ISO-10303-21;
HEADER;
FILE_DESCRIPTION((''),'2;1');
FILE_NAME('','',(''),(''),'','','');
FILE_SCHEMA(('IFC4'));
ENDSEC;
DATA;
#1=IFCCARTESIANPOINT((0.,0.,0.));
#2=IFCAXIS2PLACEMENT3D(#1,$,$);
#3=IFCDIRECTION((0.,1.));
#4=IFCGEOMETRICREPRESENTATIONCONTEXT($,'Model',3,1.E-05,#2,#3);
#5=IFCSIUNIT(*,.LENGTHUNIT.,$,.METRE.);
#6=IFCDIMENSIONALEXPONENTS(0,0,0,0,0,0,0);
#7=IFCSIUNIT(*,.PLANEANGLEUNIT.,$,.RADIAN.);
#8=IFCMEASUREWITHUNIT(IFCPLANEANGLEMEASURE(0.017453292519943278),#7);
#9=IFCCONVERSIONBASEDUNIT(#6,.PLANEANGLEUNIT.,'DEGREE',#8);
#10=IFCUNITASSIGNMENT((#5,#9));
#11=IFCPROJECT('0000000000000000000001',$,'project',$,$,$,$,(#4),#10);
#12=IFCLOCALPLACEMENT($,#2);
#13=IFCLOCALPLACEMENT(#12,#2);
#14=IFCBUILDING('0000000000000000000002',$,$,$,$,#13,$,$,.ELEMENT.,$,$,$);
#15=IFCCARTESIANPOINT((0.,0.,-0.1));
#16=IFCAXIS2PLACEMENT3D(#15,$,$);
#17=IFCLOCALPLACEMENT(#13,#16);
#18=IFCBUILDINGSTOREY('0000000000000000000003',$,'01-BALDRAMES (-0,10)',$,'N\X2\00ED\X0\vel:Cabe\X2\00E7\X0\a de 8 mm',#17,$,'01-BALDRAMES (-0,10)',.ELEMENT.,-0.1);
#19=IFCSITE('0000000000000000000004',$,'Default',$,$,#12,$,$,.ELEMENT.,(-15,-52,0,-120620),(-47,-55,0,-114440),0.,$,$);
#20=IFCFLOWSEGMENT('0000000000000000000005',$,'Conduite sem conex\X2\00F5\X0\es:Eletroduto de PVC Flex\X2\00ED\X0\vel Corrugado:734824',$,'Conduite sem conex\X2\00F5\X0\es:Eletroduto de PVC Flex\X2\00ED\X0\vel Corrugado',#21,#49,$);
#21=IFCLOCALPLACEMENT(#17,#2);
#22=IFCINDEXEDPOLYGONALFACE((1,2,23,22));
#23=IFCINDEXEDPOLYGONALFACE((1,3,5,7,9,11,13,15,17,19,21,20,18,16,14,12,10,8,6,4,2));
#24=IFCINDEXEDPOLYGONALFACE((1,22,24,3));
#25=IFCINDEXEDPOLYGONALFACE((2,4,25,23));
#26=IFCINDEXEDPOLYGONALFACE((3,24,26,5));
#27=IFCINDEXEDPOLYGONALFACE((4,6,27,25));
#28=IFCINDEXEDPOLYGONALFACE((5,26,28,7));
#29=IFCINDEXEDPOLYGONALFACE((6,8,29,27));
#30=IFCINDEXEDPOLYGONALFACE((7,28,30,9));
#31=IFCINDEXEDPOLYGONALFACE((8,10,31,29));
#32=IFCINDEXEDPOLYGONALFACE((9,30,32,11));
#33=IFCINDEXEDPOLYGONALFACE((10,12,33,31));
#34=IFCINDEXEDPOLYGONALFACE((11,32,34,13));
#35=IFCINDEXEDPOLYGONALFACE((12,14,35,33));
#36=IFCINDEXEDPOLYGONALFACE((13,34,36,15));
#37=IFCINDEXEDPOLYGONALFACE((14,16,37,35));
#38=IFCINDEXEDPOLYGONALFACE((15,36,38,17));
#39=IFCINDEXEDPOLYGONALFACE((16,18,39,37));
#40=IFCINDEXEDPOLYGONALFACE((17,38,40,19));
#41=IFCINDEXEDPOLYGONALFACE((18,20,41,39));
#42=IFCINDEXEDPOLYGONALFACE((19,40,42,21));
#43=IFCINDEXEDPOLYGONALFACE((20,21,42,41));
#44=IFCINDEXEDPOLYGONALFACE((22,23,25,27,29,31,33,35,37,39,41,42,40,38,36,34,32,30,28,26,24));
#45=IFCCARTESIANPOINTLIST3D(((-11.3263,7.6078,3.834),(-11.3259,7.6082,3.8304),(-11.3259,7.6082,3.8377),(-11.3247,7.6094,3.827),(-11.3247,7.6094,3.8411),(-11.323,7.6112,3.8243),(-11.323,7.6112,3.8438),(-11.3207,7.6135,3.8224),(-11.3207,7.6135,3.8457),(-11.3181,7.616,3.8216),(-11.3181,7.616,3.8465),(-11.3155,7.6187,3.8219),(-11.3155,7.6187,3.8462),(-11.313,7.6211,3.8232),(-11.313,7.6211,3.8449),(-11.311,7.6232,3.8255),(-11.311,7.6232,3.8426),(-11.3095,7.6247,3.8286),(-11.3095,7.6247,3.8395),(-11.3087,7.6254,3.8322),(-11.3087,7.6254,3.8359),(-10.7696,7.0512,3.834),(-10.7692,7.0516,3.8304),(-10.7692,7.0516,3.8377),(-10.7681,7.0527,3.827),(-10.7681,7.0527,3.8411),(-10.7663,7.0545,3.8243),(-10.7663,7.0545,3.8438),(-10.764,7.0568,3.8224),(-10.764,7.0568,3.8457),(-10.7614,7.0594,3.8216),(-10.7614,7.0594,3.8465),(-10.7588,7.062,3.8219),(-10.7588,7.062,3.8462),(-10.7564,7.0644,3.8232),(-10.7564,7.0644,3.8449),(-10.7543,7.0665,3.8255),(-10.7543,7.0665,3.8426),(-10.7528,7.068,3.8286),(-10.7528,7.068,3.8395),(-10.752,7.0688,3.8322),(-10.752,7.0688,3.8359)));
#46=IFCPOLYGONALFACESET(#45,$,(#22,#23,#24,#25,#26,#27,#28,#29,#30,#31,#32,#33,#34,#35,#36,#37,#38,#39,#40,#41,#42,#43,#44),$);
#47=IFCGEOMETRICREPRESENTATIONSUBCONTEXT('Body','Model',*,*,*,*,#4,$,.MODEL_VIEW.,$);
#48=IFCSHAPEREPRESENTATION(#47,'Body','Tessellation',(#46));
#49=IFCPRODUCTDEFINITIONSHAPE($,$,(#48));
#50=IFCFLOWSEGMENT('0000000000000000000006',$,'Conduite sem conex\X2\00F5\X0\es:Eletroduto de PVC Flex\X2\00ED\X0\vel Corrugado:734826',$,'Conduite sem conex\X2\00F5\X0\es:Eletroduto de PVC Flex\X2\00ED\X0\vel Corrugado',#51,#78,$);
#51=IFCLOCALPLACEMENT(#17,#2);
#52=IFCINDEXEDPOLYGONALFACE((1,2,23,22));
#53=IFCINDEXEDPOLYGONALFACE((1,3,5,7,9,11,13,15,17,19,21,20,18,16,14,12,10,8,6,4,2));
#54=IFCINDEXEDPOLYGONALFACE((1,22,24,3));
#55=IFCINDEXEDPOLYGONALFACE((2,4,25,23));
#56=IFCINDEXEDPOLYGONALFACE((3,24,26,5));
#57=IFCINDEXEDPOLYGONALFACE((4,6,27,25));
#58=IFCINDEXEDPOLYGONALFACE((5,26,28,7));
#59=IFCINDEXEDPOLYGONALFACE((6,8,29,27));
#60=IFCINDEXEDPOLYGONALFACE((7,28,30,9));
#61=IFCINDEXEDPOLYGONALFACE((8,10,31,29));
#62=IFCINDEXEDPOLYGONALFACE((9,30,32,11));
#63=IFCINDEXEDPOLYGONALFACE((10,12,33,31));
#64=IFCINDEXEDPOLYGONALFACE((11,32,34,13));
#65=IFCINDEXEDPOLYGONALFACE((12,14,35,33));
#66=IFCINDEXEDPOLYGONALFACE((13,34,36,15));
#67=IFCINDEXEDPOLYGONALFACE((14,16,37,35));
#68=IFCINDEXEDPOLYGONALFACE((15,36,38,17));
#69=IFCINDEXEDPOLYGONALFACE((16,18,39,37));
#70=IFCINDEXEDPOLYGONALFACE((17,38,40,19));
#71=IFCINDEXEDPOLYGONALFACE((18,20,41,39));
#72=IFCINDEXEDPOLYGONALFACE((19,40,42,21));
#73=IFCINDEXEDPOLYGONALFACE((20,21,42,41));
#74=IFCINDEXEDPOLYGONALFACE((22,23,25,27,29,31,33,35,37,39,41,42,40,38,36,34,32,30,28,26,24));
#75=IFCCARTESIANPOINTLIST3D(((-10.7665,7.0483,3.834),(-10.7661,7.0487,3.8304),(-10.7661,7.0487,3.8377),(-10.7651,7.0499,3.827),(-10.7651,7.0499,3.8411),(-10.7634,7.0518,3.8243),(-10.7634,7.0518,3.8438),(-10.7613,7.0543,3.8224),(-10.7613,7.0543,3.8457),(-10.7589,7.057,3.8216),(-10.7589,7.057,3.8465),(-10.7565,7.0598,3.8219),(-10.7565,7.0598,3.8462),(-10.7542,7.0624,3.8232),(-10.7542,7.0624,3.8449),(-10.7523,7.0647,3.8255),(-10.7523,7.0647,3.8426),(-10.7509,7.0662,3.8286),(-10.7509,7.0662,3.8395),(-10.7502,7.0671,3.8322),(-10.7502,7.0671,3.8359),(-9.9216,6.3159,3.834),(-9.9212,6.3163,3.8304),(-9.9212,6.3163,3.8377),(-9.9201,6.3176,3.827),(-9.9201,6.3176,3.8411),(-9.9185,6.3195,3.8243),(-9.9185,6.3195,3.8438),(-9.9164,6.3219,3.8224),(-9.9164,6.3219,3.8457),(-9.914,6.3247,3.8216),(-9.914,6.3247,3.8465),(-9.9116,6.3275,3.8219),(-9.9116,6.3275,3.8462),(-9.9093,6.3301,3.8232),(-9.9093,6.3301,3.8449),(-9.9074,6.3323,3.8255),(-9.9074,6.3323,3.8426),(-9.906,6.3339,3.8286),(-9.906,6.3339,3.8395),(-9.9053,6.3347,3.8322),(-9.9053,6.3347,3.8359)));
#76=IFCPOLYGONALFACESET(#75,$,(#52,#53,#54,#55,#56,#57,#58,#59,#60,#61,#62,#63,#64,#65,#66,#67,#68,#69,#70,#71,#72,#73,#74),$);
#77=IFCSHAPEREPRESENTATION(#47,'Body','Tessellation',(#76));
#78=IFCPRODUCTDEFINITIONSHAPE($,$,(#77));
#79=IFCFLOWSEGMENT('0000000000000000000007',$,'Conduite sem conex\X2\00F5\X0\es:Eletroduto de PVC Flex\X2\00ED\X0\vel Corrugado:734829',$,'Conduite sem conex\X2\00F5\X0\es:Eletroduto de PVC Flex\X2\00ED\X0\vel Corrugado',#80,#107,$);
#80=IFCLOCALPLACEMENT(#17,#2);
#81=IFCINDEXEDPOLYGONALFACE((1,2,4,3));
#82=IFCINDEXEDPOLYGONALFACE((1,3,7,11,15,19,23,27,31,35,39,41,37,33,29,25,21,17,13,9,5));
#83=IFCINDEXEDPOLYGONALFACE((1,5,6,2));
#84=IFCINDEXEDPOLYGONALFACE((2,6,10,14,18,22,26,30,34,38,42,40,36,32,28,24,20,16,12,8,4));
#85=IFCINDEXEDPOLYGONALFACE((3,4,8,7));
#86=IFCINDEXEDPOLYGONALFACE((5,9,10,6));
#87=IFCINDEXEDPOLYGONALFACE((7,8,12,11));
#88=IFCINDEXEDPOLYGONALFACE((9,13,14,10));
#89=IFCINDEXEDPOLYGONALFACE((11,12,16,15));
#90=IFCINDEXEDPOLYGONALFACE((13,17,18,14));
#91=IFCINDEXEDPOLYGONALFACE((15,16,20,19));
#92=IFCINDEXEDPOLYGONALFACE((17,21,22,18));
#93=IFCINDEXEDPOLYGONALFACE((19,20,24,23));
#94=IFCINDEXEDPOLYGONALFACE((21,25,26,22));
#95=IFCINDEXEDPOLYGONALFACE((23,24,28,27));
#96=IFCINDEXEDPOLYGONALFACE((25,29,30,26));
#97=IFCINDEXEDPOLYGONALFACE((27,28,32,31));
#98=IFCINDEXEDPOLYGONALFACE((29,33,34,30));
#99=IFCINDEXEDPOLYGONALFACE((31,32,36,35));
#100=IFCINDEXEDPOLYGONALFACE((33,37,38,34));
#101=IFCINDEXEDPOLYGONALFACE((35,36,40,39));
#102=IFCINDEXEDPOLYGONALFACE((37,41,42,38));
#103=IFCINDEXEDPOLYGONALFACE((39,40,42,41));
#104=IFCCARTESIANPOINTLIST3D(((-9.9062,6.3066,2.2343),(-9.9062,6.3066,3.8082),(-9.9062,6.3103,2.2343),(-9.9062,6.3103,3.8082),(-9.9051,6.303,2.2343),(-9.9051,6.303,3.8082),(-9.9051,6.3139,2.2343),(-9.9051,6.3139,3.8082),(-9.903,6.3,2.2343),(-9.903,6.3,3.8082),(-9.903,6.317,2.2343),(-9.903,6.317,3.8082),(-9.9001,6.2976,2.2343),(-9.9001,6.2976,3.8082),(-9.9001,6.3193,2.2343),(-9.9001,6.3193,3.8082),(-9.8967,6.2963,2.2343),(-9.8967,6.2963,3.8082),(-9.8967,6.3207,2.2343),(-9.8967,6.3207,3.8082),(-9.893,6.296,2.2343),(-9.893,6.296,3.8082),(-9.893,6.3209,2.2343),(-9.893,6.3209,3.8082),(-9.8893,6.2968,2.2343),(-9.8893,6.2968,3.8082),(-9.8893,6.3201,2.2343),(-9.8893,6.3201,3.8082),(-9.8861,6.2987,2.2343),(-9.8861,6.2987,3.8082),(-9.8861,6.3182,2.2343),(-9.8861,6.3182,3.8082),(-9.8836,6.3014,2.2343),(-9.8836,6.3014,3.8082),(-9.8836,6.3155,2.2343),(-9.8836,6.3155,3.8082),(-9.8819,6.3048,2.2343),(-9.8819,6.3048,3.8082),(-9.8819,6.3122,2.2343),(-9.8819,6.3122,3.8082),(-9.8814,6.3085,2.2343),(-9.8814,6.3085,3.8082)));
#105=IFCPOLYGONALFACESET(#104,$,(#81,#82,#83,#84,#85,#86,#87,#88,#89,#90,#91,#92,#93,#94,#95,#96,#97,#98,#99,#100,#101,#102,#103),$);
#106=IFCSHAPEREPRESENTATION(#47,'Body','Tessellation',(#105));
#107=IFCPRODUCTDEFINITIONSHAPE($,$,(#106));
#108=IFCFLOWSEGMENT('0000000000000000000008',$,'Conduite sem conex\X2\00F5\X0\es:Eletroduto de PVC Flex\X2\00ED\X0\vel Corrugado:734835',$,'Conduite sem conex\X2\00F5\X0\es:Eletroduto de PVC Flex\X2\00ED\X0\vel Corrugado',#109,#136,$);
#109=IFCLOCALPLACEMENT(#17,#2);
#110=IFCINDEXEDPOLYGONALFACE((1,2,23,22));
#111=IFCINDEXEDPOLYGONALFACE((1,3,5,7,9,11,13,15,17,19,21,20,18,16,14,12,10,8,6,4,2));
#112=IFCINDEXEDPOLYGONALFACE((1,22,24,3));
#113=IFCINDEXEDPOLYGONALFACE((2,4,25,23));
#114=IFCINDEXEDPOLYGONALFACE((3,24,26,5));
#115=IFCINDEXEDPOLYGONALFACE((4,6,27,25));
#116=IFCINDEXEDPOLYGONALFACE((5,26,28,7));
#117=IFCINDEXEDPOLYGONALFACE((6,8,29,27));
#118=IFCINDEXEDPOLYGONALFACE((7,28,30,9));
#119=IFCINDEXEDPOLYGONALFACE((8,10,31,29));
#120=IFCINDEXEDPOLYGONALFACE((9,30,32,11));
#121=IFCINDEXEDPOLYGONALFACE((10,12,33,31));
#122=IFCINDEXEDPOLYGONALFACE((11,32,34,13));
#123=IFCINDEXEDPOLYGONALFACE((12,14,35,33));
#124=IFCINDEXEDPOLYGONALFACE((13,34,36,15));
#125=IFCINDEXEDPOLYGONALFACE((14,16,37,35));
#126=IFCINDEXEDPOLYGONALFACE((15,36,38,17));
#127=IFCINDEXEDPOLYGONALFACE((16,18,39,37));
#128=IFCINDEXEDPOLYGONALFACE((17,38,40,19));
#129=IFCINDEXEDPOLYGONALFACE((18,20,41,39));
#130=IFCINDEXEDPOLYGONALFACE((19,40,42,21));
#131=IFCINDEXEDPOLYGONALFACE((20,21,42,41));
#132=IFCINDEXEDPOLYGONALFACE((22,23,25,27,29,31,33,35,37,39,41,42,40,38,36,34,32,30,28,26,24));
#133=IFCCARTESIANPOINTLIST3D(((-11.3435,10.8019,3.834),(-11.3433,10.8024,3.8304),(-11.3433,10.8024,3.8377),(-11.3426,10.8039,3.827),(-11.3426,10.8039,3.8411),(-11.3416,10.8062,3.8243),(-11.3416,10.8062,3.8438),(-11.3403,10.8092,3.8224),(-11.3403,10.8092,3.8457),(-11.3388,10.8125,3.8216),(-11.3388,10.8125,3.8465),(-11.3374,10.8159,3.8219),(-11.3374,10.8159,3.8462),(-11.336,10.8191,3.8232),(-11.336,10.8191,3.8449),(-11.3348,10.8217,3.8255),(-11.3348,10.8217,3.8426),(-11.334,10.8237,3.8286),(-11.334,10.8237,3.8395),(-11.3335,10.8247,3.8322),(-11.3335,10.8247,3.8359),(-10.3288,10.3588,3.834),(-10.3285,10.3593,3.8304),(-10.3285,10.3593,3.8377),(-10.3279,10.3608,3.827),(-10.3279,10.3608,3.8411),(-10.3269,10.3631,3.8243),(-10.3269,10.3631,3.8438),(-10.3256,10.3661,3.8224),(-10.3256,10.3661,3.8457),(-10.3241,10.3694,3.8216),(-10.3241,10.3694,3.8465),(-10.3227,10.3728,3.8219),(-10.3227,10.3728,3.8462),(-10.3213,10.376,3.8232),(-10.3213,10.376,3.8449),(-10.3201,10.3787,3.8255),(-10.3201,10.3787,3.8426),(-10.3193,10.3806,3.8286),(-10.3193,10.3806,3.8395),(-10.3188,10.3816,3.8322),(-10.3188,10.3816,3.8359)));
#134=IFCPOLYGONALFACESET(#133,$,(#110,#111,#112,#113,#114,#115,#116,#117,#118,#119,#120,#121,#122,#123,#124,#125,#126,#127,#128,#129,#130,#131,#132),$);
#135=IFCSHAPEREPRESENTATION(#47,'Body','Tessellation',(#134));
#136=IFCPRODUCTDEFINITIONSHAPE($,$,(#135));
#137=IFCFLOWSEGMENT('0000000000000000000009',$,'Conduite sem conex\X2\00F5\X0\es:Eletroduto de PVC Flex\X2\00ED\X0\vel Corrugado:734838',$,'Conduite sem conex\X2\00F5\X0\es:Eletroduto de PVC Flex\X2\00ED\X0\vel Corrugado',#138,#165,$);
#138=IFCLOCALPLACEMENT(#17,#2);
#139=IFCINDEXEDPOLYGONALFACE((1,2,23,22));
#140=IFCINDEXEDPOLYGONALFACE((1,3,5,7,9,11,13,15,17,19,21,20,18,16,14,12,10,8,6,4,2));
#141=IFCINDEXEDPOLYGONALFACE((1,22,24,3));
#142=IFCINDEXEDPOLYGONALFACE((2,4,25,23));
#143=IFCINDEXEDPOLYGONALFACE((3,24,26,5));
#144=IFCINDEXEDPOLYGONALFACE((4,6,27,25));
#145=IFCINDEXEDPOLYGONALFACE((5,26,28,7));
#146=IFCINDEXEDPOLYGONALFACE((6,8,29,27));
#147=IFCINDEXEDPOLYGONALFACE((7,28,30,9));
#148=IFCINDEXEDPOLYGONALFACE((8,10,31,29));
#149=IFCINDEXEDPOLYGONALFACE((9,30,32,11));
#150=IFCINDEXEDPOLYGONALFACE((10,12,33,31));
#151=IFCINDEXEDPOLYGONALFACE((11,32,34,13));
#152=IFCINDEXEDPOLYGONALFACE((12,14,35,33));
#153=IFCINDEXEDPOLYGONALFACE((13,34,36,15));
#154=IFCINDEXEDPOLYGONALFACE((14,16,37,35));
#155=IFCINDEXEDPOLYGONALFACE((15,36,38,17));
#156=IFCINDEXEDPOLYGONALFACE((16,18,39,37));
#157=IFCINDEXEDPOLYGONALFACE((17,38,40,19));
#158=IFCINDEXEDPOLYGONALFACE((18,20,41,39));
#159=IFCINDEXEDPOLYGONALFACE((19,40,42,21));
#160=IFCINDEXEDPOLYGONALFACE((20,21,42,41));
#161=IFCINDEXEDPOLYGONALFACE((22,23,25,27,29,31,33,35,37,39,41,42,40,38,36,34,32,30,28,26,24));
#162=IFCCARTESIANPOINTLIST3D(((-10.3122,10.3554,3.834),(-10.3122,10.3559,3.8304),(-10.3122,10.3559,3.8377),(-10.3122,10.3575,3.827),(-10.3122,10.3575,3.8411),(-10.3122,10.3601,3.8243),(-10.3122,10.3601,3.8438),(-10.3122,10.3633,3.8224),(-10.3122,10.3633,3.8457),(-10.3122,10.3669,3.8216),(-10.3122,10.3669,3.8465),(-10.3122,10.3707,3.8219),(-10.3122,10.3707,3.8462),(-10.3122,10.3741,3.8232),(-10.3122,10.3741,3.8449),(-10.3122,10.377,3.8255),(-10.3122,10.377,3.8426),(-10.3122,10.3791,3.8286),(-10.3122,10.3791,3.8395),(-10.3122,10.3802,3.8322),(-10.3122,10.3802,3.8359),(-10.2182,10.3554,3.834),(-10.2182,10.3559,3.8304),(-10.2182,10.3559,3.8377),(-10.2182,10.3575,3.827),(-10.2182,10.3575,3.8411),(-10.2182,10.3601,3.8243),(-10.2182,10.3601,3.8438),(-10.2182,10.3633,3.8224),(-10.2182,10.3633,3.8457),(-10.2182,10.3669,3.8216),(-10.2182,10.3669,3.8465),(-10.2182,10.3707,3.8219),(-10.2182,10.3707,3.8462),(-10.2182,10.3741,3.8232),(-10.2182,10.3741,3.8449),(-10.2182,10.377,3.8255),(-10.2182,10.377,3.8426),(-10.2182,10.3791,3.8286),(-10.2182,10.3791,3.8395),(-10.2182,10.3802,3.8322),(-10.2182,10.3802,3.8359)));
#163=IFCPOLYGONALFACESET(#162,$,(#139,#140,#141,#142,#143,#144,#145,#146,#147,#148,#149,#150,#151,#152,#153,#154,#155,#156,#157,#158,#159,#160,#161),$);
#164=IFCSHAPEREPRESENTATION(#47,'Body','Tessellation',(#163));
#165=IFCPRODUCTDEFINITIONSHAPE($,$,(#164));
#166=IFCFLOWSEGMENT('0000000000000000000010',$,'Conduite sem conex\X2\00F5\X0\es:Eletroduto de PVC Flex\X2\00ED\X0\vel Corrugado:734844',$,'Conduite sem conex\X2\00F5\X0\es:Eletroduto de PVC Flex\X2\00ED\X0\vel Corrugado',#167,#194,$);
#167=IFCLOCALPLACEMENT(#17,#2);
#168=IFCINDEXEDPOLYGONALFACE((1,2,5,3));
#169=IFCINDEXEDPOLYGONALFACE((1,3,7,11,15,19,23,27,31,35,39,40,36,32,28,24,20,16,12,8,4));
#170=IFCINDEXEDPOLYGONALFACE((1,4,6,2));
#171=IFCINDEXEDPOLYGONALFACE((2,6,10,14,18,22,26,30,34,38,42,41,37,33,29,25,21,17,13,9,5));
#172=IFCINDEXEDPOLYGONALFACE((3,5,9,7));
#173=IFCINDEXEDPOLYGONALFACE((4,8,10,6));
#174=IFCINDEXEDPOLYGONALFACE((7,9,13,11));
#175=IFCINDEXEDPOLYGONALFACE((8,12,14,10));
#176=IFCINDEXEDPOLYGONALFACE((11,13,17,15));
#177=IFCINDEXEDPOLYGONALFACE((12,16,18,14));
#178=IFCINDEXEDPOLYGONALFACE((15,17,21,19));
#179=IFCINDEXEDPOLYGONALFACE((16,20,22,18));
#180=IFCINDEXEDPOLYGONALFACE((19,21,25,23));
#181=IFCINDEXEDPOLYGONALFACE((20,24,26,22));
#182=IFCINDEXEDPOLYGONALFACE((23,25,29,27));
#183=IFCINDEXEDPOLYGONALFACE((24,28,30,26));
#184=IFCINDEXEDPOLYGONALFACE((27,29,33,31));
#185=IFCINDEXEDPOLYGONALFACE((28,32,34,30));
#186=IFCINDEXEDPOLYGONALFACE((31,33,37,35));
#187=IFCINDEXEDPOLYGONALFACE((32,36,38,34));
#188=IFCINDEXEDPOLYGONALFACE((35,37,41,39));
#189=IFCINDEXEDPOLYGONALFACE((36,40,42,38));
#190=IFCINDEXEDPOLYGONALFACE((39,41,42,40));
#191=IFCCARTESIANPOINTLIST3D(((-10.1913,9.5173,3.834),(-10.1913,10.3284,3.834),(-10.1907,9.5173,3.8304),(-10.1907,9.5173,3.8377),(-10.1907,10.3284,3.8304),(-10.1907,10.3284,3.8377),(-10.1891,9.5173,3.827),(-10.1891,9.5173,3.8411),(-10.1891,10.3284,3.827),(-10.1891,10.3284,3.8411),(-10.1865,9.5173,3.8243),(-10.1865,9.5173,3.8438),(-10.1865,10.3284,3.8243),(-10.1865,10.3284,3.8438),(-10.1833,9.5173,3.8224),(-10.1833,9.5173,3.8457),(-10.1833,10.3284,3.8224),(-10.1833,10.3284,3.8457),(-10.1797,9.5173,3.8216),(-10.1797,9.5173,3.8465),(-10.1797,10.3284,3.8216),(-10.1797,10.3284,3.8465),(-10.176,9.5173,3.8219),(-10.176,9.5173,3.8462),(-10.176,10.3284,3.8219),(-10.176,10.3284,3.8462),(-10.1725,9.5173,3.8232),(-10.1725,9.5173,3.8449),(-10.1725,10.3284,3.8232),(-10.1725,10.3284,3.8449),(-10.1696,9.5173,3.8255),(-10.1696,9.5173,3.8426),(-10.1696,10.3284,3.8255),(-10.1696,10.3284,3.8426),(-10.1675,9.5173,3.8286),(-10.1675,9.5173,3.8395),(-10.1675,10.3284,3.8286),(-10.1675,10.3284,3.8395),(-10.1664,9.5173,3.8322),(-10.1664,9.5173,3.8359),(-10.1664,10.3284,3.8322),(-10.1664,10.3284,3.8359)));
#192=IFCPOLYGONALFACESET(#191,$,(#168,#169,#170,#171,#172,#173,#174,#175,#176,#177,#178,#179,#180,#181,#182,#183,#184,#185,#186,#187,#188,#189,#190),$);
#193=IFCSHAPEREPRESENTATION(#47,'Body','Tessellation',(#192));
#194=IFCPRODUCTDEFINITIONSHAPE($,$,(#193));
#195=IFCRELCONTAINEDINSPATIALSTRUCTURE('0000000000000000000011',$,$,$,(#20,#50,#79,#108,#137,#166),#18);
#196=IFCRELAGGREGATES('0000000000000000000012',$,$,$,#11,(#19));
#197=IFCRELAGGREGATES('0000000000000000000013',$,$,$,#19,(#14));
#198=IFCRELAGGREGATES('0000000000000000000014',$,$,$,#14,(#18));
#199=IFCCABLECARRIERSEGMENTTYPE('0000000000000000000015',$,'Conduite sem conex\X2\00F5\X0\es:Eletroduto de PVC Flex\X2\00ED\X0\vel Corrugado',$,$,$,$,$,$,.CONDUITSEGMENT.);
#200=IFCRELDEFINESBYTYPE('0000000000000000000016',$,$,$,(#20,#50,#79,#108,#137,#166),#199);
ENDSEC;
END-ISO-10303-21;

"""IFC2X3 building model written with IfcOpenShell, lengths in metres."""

from ifc_helpers import new_model, entity, si_unit, converted_unit, direction, frame, frame_2d, origin, origin_2d_with_axis, place, context, subcontext, project, spatial, circle, extrude, type_object, element, save


model = new_model("IFC2X3")

# Units and contexts
model_context = context("Model", 3, precision=1e-05, world=origin(), true_north=direction((0.0, 1.0)))
body_context = subcontext(model_context, "Body", "Model", "MODEL_VIEW")
ifc_project = project(units=[si_unit("LENGTHUNIT", "METRE"), converted_unit("PLANEANGLEUNIT", "DEGREE", entity("IfcPlaneAngleMeasure", 0.017453292519943278), si_unit("PLANEANGLEUNIT", "RADIAN"), dimensions=[0, 0, 0, 0, 0, 0, 0])], contexts=[model_context])

# Site, building, storey
site_placement = place(None, origin())
site = spatial("IfcSite", under=ifc_project, at=site_placement, Name="Default", CompositionType="ELEMENT", RefLatitude=(-15, -52, 0, -120620), RefLongitude=(-47, -55, 0, -114440), RefElevation=0.0)
building_placement = place(site_placement, origin())
building = spatial("IfcBuilding", under=site, at=building_placement, CompositionType="ELEMENT")
storey_placement = place(building_placement, frame((0.0, 0.0, -0.1)))
storey = spatial("IfcBuildingStorey", under=building, at=storey_placement, Name="01-BALDRAMES (-0,10)", ObjectType="Nível:Cabeça de 8 mm", LongName="01-BALDRAMES (-0,10)", CompositionType="ELEMENT", Elevation=-0.1)

# Flow segments
cable_carrier_segment_type = type_object("IfcCableCarrierSegmentType", Name="Conduite sem conexões:Eletroduto de PVC Flexível Corrugado", PredefinedType="CONDUITSEGMENT")
flow_segment_1_placement = place(storey_placement, origin())
element("IfcFlowSegment", 1, at=flow_segment_1_placement, inside=storey, type_object=cable_carrier_segment_type, Name="Conduite sem conexões:Eletroduto de PVC Flexível Corrugado:734824", ObjectType="Conduite sem conexões:Eletroduto de PVC Flexível Corrugado", context=body_context, shape_type="SweptSolid", body=[
    extrude(circle(Radius=0.0125, at=origin_2d_with_axis()), frame((-10.7608, 7.06, 3.834), z_axis=(-0.707107, 0.707107, 0.0), x_axis=(-0.707107, -0.707107, 0.0)), (0.0, 0.0, 1.0), 0.7872),
])
flow_segment_2_placement = place(storey_placement, origin())
element("IfcFlowSegment", 2, at=flow_segment_2_placement, inside=storey, type_object=cable_carrier_segment_type, Name="Conduite sem conexões:Eletroduto de PVC Flexível Corrugado:734826", ObjectType="Conduite sem conexões:Eletroduto de PVC Flexível Corrugado", context=body_context, shape_type="SweptSolid", body=[
    extrude(circle(Radius=0.0125, at=frame_2d((0.0, 0.0), x_axis=(1.0, 0.0))), frame((-9.9134, 6.3254, 3.834), z_axis=(-0.75565, 0.654975, 0.0), x_axis=(-0.654975, -0.75565, 0.0)), (0.0, 0.0, 1.0), 1.1181),
])
flow_segment_3_placement = place(storey_placement, origin())
element("IfcFlowSegment", 3, at=flow_segment_3_placement, inside=storey, type_object=cable_carrier_segment_type, Name="Conduite sem conexões:Eletroduto de PVC Flexível Corrugado:734829", ObjectType="Conduite sem conexões:Eletroduto de PVC Flexível Corrugado", context=body_context, shape_type="SweptSolid", body=[
    extrude(circle(Radius=0.0125, at=frame_2d((0.0, 0.0), x_axis=(1.0, 0.0))), frame((-9.8939, 6.3085, 2.2343)), (0.0, 0.0, 1.0), 1.574),
])
flow_segment_4_placement = place(storey_placement, origin())
element("IfcFlowSegment", 4, at=flow_segment_4_placement, inside=storey, type_object=cable_carrier_segment_type, Name="Conduite sem conexões:Eletroduto de PVC Flexível Corrugado:734835", ObjectType="Conduite sem conexões:Eletroduto de PVC Flexível Corrugado", context=body_context, shape_type="SweptSolid", body=[
    extrude(circle(Radius=0.0125, at=origin_2d_with_axis()), frame((-10.3238, 10.3703, 3.834), z_axis=(-0.916445, 0.400161, 0.0), x_axis=(-0.400161, -0.916445, 0.0)), (0.0, 0.0, 1.0), 1.1072),
])
flow_segment_5_placement = place(storey_placement, origin())
element("IfcFlowSegment", 5, at=flow_segment_5_placement, inside=storey, type_object=cable_carrier_segment_type, Name="Conduite sem conexões:Eletroduto de PVC Flexível Corrugado:734838", ObjectType="Conduite sem conexões:Eletroduto de PVC Flexível Corrugado", context=body_context, shape_type="SweptSolid", body=[
    extrude(circle(Radius=0.0125, at=origin_2d_with_axis()), frame((-10.3122, 10.3679, 3.834), z_axis=(1.0, 0.0, 0.0), x_axis=(0.0, -1.0, 0.0)), (0.0, 0.0, 1.0), 0.094),
])
flow_segment_6_placement = place(storey_placement, origin())
element("IfcFlowSegment", 6, at=flow_segment_6_placement, inside=storey, type_object=cable_carrier_segment_type, Name="Conduite sem conexões:Eletroduto de PVC Flexível Corrugado:734844", ObjectType="Conduite sem conexões:Eletroduto de PVC Flexível Corrugado", context=body_context, shape_type="SweptSolid", body=[
    extrude(circle(Radius=0.0125, at=frame_2d((0.0, 0.0), x_axis=(1.0, 0.0))), frame((-10.1788, 9.5173, 3.834), z_axis=(0.0, 1.0, 0.0), x_axis=(-1.0, 0.0, 0.0)), (0.0, 0.0, 1.0), 0.8111),
])

save(model, "model.ifc")
